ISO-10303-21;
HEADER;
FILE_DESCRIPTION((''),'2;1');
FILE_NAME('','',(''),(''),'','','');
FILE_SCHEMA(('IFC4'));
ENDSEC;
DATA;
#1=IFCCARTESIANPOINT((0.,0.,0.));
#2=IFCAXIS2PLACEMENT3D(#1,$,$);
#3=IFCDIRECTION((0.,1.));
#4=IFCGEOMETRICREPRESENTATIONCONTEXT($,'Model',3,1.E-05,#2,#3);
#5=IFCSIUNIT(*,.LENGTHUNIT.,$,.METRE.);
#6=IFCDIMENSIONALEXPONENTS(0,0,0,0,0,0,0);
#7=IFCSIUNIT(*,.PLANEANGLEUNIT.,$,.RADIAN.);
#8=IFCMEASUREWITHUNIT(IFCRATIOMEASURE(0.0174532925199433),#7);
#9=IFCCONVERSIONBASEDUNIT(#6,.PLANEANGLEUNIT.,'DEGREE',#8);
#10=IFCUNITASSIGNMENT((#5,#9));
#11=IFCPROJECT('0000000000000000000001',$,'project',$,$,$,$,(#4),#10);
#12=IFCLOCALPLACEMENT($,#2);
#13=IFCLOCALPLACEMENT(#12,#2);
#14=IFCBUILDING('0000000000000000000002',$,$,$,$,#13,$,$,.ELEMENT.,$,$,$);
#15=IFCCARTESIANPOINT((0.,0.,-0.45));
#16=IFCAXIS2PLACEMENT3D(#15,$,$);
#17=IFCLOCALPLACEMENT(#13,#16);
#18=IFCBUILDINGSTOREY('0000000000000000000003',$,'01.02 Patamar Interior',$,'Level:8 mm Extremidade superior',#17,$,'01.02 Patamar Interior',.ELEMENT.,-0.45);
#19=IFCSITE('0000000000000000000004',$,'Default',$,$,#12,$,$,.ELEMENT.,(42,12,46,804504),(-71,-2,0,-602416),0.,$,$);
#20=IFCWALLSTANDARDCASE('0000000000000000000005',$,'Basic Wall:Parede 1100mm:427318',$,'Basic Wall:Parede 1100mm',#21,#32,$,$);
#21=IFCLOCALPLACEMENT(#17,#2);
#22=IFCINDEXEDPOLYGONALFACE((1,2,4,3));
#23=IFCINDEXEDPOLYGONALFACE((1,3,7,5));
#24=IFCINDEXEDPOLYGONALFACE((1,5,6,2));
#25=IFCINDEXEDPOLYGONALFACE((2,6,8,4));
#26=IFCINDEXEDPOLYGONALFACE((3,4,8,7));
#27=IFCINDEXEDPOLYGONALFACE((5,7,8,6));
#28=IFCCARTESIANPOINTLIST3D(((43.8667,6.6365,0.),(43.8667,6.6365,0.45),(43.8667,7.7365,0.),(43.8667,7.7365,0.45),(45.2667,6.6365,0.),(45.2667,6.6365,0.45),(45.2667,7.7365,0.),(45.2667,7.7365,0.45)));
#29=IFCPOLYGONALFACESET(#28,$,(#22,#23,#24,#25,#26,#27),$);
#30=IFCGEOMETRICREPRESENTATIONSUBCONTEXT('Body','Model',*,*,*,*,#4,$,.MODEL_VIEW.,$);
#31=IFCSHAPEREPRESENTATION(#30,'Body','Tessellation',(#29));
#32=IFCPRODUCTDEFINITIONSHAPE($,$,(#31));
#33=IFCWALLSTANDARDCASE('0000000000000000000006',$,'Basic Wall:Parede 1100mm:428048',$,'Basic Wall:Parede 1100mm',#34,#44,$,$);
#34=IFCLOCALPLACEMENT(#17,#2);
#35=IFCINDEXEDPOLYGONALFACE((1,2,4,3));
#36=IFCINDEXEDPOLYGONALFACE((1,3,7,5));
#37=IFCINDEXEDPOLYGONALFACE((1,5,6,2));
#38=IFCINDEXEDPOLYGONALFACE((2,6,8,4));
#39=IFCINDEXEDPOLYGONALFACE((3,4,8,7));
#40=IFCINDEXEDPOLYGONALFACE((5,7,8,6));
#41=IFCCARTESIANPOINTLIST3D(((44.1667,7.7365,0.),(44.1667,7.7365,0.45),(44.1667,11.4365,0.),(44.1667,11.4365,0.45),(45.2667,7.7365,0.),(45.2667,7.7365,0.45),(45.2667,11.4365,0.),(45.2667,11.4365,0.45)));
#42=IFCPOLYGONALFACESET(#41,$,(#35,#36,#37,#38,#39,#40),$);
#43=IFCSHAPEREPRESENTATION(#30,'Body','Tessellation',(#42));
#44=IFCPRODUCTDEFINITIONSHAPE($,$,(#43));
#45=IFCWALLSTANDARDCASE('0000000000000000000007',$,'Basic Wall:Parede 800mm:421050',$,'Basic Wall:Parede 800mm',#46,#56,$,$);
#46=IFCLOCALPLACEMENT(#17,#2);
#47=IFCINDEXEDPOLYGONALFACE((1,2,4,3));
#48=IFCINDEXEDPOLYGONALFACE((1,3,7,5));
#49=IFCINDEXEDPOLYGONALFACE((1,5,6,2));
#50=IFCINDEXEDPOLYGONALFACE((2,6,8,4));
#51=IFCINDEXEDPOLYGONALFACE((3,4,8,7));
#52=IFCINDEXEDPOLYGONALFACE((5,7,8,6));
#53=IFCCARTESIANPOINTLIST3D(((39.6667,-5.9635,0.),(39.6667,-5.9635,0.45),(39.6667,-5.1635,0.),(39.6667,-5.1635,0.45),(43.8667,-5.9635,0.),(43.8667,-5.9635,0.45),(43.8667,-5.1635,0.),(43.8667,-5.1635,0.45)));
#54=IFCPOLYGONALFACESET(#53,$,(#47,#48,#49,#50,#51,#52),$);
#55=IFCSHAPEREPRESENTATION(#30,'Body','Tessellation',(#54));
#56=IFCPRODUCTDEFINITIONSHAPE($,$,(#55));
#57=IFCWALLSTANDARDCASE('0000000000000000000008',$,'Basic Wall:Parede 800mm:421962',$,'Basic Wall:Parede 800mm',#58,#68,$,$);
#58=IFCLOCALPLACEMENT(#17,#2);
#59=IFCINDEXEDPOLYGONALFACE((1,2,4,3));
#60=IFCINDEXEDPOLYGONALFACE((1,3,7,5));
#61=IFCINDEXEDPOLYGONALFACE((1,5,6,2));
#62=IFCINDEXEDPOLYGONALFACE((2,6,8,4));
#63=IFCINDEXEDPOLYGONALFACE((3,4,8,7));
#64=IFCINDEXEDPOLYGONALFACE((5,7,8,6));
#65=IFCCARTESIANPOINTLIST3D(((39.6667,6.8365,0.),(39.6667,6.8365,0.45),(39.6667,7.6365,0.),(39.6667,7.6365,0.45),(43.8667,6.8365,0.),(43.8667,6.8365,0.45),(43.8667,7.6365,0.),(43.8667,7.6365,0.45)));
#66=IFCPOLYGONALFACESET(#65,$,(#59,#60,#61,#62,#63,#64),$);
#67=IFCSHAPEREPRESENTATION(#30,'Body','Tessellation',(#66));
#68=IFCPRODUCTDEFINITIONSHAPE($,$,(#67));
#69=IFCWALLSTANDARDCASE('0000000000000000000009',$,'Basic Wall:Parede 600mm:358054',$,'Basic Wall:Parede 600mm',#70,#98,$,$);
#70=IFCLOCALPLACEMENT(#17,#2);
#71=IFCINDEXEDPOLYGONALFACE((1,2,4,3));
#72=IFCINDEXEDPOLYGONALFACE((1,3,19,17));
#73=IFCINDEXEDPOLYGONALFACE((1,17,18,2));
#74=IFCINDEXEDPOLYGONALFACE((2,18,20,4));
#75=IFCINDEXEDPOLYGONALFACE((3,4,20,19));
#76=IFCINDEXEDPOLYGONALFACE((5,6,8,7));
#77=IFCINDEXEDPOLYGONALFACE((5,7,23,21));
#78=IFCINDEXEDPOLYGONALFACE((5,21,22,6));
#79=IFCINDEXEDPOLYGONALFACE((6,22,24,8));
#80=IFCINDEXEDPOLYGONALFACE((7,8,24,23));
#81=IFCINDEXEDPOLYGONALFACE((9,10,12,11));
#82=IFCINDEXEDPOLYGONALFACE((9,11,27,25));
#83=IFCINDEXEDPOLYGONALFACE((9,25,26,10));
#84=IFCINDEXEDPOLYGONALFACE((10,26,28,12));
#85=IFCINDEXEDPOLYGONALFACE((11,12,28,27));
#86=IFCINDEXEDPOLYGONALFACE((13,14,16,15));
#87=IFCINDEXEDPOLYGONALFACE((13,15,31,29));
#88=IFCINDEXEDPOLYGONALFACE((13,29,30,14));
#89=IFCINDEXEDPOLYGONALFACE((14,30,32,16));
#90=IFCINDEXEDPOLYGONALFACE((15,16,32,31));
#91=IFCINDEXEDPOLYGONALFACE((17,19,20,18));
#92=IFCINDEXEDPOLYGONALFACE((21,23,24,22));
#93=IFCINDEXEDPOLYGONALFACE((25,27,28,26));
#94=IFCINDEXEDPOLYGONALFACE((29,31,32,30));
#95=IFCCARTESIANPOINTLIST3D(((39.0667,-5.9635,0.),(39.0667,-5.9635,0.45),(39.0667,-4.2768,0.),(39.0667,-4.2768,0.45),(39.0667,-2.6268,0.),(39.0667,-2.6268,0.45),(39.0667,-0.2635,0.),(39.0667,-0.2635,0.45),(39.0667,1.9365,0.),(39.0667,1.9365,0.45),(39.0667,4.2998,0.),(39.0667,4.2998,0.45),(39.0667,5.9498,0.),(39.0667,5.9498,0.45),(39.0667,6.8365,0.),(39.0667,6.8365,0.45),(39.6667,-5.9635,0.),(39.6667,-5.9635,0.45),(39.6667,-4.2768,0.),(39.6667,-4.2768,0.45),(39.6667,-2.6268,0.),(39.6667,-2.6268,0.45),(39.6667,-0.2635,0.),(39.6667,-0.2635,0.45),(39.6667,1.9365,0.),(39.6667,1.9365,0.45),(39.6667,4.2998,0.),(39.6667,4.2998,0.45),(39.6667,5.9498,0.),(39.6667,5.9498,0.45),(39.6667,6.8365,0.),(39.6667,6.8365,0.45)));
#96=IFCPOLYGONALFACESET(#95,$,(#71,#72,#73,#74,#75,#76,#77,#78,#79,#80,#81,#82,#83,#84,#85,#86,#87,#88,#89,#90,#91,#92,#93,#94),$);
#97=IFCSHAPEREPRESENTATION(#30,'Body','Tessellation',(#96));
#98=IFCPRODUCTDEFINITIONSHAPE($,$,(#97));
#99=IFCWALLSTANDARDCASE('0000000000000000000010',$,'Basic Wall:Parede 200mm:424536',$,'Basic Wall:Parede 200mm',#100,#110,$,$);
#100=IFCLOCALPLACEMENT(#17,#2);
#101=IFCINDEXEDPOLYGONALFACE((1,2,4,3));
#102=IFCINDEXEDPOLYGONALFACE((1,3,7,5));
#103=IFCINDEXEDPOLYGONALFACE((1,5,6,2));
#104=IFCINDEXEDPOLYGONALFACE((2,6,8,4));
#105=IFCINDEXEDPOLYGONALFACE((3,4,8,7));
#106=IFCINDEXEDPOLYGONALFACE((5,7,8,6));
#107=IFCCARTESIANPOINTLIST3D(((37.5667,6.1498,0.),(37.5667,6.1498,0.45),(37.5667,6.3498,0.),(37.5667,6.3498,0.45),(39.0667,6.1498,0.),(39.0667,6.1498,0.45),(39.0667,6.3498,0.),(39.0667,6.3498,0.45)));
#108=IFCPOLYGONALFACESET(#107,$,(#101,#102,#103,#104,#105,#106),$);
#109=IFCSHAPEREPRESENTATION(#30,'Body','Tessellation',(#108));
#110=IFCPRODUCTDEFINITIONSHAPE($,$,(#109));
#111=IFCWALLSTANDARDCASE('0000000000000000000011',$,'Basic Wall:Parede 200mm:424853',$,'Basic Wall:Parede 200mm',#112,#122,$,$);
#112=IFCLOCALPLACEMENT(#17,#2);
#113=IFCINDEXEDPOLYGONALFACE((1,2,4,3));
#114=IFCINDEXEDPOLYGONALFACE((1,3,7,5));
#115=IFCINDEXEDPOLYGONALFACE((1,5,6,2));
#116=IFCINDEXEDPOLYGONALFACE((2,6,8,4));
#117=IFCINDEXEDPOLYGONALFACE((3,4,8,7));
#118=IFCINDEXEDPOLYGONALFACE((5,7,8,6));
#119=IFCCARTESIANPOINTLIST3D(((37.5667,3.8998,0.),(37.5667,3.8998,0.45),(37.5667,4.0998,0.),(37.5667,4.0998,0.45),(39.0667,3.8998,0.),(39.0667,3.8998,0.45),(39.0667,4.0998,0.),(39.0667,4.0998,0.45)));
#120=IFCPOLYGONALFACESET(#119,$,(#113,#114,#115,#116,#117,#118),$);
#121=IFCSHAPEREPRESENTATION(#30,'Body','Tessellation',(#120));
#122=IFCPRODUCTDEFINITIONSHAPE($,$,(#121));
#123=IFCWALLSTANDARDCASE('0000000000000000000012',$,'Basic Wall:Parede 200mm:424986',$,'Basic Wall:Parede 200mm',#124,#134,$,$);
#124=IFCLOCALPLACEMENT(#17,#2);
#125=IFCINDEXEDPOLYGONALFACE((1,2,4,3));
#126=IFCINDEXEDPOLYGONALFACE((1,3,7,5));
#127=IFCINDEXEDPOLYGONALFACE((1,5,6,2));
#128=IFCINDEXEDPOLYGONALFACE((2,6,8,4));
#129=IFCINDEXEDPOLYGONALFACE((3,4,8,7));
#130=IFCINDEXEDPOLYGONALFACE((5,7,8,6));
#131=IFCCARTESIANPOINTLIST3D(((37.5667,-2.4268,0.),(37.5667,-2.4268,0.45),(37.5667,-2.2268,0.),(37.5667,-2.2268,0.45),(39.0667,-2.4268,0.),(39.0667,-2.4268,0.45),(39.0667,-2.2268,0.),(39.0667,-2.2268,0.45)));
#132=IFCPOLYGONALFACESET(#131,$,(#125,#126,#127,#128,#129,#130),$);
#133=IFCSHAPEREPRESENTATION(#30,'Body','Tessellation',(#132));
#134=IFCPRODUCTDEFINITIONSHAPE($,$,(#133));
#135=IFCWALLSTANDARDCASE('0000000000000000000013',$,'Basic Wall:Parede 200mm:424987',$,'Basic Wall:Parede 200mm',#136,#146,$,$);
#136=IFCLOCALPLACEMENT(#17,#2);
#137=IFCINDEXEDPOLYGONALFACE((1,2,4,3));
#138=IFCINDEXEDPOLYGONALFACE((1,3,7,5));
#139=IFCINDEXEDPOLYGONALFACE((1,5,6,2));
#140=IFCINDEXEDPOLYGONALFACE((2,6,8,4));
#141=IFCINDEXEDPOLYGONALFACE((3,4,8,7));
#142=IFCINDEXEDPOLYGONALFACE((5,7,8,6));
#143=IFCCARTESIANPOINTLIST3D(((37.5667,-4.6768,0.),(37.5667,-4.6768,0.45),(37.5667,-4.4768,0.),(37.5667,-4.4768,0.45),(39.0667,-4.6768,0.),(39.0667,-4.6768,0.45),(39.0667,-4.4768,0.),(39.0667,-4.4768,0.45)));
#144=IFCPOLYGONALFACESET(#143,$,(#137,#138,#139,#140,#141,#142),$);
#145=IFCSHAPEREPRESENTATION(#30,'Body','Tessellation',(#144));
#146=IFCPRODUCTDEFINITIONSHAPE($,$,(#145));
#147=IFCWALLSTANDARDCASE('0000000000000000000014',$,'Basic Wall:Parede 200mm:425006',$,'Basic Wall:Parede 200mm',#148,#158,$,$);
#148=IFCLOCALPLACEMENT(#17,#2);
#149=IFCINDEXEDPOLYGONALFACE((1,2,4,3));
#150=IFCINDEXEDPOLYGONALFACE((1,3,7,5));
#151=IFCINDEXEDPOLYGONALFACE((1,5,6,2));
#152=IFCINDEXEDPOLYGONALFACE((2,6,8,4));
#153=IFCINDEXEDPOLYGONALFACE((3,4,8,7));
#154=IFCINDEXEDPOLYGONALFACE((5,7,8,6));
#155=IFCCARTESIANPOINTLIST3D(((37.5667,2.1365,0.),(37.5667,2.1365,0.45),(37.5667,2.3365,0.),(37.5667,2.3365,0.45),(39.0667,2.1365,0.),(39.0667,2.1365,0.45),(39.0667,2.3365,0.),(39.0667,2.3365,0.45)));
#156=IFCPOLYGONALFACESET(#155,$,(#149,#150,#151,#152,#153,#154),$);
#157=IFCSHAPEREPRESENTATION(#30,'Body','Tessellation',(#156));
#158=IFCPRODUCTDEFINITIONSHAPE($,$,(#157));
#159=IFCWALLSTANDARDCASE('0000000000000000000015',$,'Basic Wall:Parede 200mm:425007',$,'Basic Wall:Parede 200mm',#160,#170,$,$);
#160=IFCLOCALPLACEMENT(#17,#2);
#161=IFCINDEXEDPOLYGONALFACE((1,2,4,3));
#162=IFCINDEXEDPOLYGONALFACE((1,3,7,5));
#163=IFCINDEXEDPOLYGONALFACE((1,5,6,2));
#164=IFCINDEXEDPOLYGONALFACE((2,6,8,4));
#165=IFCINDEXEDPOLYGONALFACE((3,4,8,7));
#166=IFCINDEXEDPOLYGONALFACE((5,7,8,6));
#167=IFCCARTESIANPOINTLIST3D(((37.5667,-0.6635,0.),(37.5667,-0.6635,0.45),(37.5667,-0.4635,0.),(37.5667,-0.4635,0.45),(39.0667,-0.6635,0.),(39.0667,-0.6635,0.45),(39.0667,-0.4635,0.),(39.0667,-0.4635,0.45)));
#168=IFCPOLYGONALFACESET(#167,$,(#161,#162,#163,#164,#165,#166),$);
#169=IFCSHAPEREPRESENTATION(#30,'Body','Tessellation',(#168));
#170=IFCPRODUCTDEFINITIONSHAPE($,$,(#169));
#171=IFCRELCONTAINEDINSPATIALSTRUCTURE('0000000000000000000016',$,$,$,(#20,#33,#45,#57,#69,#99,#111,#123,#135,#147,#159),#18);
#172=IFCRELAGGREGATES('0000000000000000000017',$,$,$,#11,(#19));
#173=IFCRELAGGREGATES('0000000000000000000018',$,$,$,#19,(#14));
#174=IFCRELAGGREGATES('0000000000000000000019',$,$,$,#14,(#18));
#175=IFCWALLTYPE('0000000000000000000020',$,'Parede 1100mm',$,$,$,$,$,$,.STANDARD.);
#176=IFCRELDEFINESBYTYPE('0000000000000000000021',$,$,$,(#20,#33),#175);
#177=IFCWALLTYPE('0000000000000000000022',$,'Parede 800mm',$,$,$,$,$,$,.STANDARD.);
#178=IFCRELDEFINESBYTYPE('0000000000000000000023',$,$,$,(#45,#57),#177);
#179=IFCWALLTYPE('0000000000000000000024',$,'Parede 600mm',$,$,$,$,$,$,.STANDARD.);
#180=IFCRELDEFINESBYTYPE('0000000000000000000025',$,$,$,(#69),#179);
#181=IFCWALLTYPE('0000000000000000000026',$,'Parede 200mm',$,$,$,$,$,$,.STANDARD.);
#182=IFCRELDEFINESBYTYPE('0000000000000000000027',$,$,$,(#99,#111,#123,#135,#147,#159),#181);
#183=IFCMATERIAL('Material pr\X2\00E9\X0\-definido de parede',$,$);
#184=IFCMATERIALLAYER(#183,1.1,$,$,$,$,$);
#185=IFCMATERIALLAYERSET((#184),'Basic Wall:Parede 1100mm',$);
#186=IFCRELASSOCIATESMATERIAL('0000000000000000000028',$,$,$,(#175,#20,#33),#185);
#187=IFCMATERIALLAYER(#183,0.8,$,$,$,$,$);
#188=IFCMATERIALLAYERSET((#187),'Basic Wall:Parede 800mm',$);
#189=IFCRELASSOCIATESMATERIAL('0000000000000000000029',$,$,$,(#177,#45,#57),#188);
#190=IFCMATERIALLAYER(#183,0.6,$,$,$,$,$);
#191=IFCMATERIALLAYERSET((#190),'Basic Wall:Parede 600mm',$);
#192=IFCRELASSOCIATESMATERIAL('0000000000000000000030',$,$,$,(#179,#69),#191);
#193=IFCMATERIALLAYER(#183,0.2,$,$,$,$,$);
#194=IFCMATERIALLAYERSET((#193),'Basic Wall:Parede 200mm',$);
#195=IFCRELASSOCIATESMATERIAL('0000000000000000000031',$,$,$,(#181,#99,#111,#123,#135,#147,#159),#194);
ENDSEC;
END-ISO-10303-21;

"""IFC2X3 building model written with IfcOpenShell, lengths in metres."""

from ifc_helpers import new_model, entity, si_unit, converted_unit, direction, frame, frame_2d, origin, place, context, subcontext, project, spatial, rectangle, extrude, clip, halfspace, material, layer, layer_set, layer_usage, type_object, element, save


model = new_model("IFC2X3")

# Units and contexts
model_context = context("Model", 3, precision=1e-05, world=origin(), true_north=direction((0.0, 1.0)))
body_context = subcontext(model_context, "Body", "Model", "MODEL_VIEW")
ifc_project = project(units=[si_unit("LENGTHUNIT", "METRE"), converted_unit("PLANEANGLEUNIT", "DEGREE", entity("IfcRatioMeasure", 0.0174532925199433), si_unit("PLANEANGLEUNIT", "RADIAN"), dimensions=[0, 0, 0, 0, 0, 0, 0])], contexts=[model_context])

# Site, building, storey
site_placement = place(None, origin())
site = spatial("IfcSite", under=ifc_project, at=site_placement, Name="Default", CompositionType="ELEMENT", RefLatitude=(42, 12, 46, 804504), RefLongitude=(-71, -2, 0, -602416), RefElevation=0.0)
building_placement = place(site_placement, origin())
building = spatial("IfcBuilding", under=site, at=building_placement, CompositionType="ELEMENT")
storey_placement = place(building_placement, frame((0.0, 0.0, -0.45)))
storey = spatial("IfcBuildingStorey", under=building, at=storey_placement, Name="01.02 Patamar Interior", ObjectType="Level:8 mm Extremidade superior", LongName="01.02 Patamar Interior", CompositionType="ELEMENT", Elevation=-0.45)

# Walls
ifc_material_1 = material(Name="Material pré-definido de parede")
ifc_layer_1 = layer(ifc_material_1, 1.1)
ifc_layer_set_1 = layer_set([ifc_layer_1], Name="Basic Wall:Parede 1100mm")
wall_type_1 = type_object("IfcWallType", Name="Parede 1100mm", PredefinedType="STANDARD", material=ifc_layer_set_1)
ifc_layer_usage_1 = layer_usage(ifc_layer_set_1, "AXIS2", "POSITIVE", -0.55)
wall_1_placement = place(storey_placement, frame((45.2667, 7.1865, 0.0), z_axis=(0.0, 0.0, 1.0), x_axis=(-1.0, 0.0, 0.0)))
element("IfcWallStandardCase", 1, at=wall_1_placement, inside=storey, type_object=wall_type_1, material=ifc_layer_usage_1, Name="Basic Wall:Parede 1100mm:427318", ObjectType="Basic Wall:Parede 1100mm", context=body_context, shape_type="Clipping", body=[
    clip(extrude(rectangle(XDim=1.4, YDim=1.1, at=frame_2d((0.7, 0.0), x_axis=(-1.0, 0.0))), origin(), (0.0, 0.0, 1.0), 0.45), halfspace(frame((0.0, 0.0, -2.4)), True)),
])
ifc_layer_usage_2 = layer_usage(ifc_layer_set_1, "AXIS2", "POSITIVE", -0.55)
wall_2_placement = place(storey_placement, frame((44.7167, 7.7365, 0.0), z_axis=(0.0, 0.0, 1.0), x_axis=(0.0, 1.0, 0.0)))
element("IfcWallStandardCase", 2, at=wall_2_placement, inside=storey, type_object=wall_type_1, material=ifc_layer_usage_2, Name="Basic Wall:Parede 1100mm:428048", ObjectType="Basic Wall:Parede 1100mm", context=body_context, shape_type="Clipping", body=[
    clip(extrude(rectangle(XDim=3.7, YDim=1.1, at=frame_2d((1.85, 0.0), x_axis=(-1.0, 0.0))), origin(), (0.0, 0.0, 1.0), 0.45), halfspace(frame((0.0, 0.0, -2.4)), True)),
])
ifc_layer_2 = layer(ifc_material_1, 0.8)
ifc_layer_set_2 = layer_set([ifc_layer_2], Name="Basic Wall:Parede 800mm")
ifc_layer_usage_3 = layer_usage(ifc_layer_set_2, "AXIS2", "POSITIVE", -0.4)
wall_type_2 = type_object("IfcWallType", Name="Parede 800mm", PredefinedType="STANDARD", material=ifc_layer_set_2)
wall_3_placement = place(storey_placement, frame((39.6667, -5.5635, 0.0)))
element("IfcWallStandardCase", 3, at=wall_3_placement, inside=storey, type_object=wall_type_2, material=ifc_layer_usage_3, Name="Basic Wall:Parede 800mm:421050", ObjectType="Basic Wall:Parede 800mm", context=body_context, shape_type="Clipping", body=[
    clip(extrude(rectangle(XDim=4.2, YDim=0.8, at=frame_2d((2.1, 0.0), x_axis=(-1.0, 0.0))), origin(), (0.0, 0.0, 1.0), 0.45), halfspace(frame((0.0, 0.0, -0.45)), True)),
])
ifc_layer_usage_4 = layer_usage(ifc_layer_set_2, "AXIS2", "NEGATIVE", 0.4)
wall_4_placement = place(storey_placement, frame((39.6667, 7.2365, 0.0)))
element("IfcWallStandardCase", 4, at=wall_4_placement, inside=storey, type_object=wall_type_2, material=ifc_layer_usage_4, Name="Basic Wall:Parede 800mm:421962", ObjectType="Basic Wall:Parede 800mm", context=body_context, shape_type="Clipping", body=[
    clip(extrude(rectangle(XDim=4.2, YDim=0.8, at=frame_2d((2.1, 0.0), x_axis=(-1.0, 0.0))), origin(), (0.0, 0.0, 1.0), 0.45), halfspace(frame((0.0, 0.0, -0.45)), True)),
])

# Wall, openings
ifc_layer_3 = layer(ifc_material_1, 0.6)
ifc_layer_set_3 = layer_set([ifc_layer_3], Name="Basic Wall:Parede 600mm")
ifc_layer_usage_5 = layer_usage(ifc_layer_set_3, "AXIS2", "NEGATIVE", 0.3)
wall_type_3 = type_object("IfcWallType", Name="Parede 600mm", PredefinedType="STANDARD", material=ifc_layer_set_3)
wall_5_placement = place(storey_placement, frame((39.3667, 6.8365, 0.0), z_axis=(0.0, 0.0, 1.0), x_axis=(0.0, -1.0, 0.0)))
wall_5 = element("IfcWallStandardCase", 5, at=wall_5_placement, inside=storey, type_object=wall_type_3, material=ifc_layer_usage_5, Name="Basic Wall:Parede 600mm:358054", ObjectType="Basic Wall:Parede 600mm", context=body_context, shape_type="Clipping", body=[
    clip(extrude(rectangle(XDim=12.8, YDim=0.6, at=frame_2d((6.4, 0.0), x_axis=(-1.0, 0.0))), origin(), (0.0, 0.0, 1.0), 0.45), halfspace(frame((0.0, 0.0, -0.45)), True)),
])
opening_1_placement = place(wall_5_placement, frame((9.4633, -0.3, 0.0)))
element("IfcOpeningElement", 6, at=opening_1_placement, cuts=wall_5, ObjectType="Opening", context=body_context, shape_type="SweptSolid", body=[
    extrude(rectangle(XDim=3.85, YDim=1.65, at=frame_2d((1.925, 0.825), x_axis=(1.0, 0.0))), frame((0.0, 0.0, 0.0), z_axis=(0.0, 1.0, 0.0), x_axis=(0.0, 0.0, 1.0)), (0.0, 0.0, 1.0), 0.6),
])
opening_2_placement = place(wall_5_placement, frame((4.9, -0.3, 0.0)))
element("IfcOpeningElement", 7, at=opening_2_placement, cuts=wall_5, ObjectType="Opening", context=body_context, shape_type="SweptSolid", body=[
    extrude(rectangle(XDim=3.85, YDim=2.2, at=frame_2d((1.925, 1.1), x_axis=(1.0, 0.0))), frame((0.0, 0.0, 0.0), z_axis=(0.0, 1.0, 0.0), x_axis=(0.0, 0.0, 1.0)), (0.0, 0.0, 1.0), 0.6),
])
opening_3_placement = place(wall_5_placement, frame((0.8867, -0.3, 0.0)))
element("IfcOpeningElement", 8, at=opening_3_placement, cuts=wall_5, ObjectType="Opening", context=body_context, shape_type="SweptSolid", body=[
    extrude(rectangle(XDim=3.85, YDim=1.65, at=frame_2d((1.925, 0.825), x_axis=(1.0, 0.0))), frame((0.0, 0.0, 0.0), z_axis=(0.0, 1.0, 0.0), x_axis=(0.0, 0.0, 1.0)), (0.0, 0.0, 1.0), 0.6),
])

# Walls
ifc_layer_4 = layer(ifc_material_1, 0.2)
ifc_layer_set_4 = layer_set([ifc_layer_4], Name="Basic Wall:Parede 200mm")
ifc_layer_usage_6 = layer_usage(ifc_layer_set_4, "AXIS2", "NEGATIVE", 0.1)
wall_type_4 = type_object("IfcWallType", Name="Parede 200mm", PredefinedType="STANDARD", material=ifc_layer_set_4)
wall_6_placement = place(storey_placement, frame((39.0667, 6.2498, 0.0), z_axis=(0.0, 0.0, 1.0), x_axis=(-1.0, 0.0, 0.0)))
element("IfcWallStandardCase", 9, at=wall_6_placement, inside=storey, type_object=wall_type_4, material=ifc_layer_usage_6, Name="Basic Wall:Parede 200mm:424536", ObjectType="Basic Wall:Parede 200mm", context=body_context, shape_type="SweptSolid", body=[
    extrude(rectangle(XDim=1.5, YDim=0.2, at=frame_2d((0.75, 0.0), x_axis=(-1.0, 0.0))), origin(), (0.0, 0.0, 1.0), 0.45),
])
ifc_layer_usage_7 = layer_usage(ifc_layer_set_4, "AXIS2", "NEGATIVE", 0.1)
wall_7_placement = place(storey_placement, frame((39.0667, 3.9998, 0.0), z_axis=(0.0, 0.0, 1.0), x_axis=(-1.0, 0.0, 0.0)))
element("IfcWallStandardCase", 10, at=wall_7_placement, inside=storey, type_object=wall_type_4, material=ifc_layer_usage_7, Name="Basic Wall:Parede 200mm:424853", ObjectType="Basic Wall:Parede 200mm", context=body_context, shape_type="SweptSolid", body=[
    extrude(rectangle(XDim=1.5, YDim=0.2, at=frame_2d((0.75, 0.0), x_axis=(-1.0, 0.0))), origin(), (0.0, 0.0, 1.0), 0.45),
])
ifc_layer_usage_8 = layer_usage(ifc_layer_set_4, "AXIS2", "NEGATIVE", 0.1)
wall_8_placement = place(storey_placement, frame((39.0667, -2.3268, 0.0), z_axis=(0.0, 0.0, 1.0), x_axis=(-1.0, 0.0, 0.0)))
element("IfcWallStandardCase", 11, at=wall_8_placement, inside=storey, type_object=wall_type_4, material=ifc_layer_usage_8, Name="Basic Wall:Parede 200mm:424986", ObjectType="Basic Wall:Parede 200mm", context=body_context, shape_type="SweptSolid", body=[
    extrude(rectangle(XDim=1.5, YDim=0.2, at=frame_2d((0.75, 0.0), x_axis=(-1.0, 0.0))), origin(), (0.0, 0.0, 1.0), 0.45),
])
ifc_layer_usage_9 = layer_usage(ifc_layer_set_4, "AXIS2", "NEGATIVE", 0.1)
wall_9_placement = place(storey_placement, frame((39.0667, -4.5768, 0.0), z_axis=(0.0, 0.0, 1.0), x_axis=(-1.0, 0.0, 0.0)))
element("IfcWallStandardCase", 12, at=wall_9_placement, inside=storey, type_object=wall_type_4, material=ifc_layer_usage_9, Name="Basic Wall:Parede 200mm:424987", ObjectType="Basic Wall:Parede 200mm", context=body_context, shape_type="SweptSolid", body=[
    extrude(rectangle(XDim=1.5, YDim=0.2, at=frame_2d((0.75, 0.0), x_axis=(-1.0, 0.0))), origin(), (0.0, 0.0, 1.0), 0.45),
])
ifc_layer_usage_10 = layer_usage(ifc_layer_set_4, "AXIS2", "NEGATIVE", 0.1)
wall_10_placement = place(storey_placement, frame((39.0667, 2.2365, 0.0), z_axis=(0.0, 0.0, 1.0), x_axis=(-1.0, 0.0, 0.0)))
element("IfcWallStandardCase", 13, at=wall_10_placement, inside=storey, type_object=wall_type_4, material=ifc_layer_usage_10, Name="Basic Wall:Parede 200mm:425006", ObjectType="Basic Wall:Parede 200mm", context=body_context, shape_type="SweptSolid", body=[
    extrude(rectangle(XDim=1.5, YDim=0.2, at=frame_2d((0.75, 0.0), x_axis=(-1.0, 0.0))), origin(), (0.0, 0.0, 1.0), 0.45),
])
ifc_layer_usage_11 = layer_usage(ifc_layer_set_4, "AXIS2", "NEGATIVE", 0.1)
wall_11_placement = place(storey_placement, frame((39.0667, -0.5635, 0.0), z_axis=(0.0, 0.0, 1.0), x_axis=(-1.0, 0.0, 0.0)))
element("IfcWallStandardCase", 14, at=wall_11_placement, inside=storey, type_object=wall_type_4, material=ifc_layer_usage_11, Name="Basic Wall:Parede 200mm:425007", ObjectType="Basic Wall:Parede 200mm", context=body_context, shape_type="SweptSolid", body=[
    extrude(rectangle(XDim=1.5, YDim=0.2, at=frame_2d((0.75, 0.0), x_axis=(-1.0, 0.0))), origin(), (0.0, 0.0, 1.0), 0.45),
])

save(model, "model.ifc")
